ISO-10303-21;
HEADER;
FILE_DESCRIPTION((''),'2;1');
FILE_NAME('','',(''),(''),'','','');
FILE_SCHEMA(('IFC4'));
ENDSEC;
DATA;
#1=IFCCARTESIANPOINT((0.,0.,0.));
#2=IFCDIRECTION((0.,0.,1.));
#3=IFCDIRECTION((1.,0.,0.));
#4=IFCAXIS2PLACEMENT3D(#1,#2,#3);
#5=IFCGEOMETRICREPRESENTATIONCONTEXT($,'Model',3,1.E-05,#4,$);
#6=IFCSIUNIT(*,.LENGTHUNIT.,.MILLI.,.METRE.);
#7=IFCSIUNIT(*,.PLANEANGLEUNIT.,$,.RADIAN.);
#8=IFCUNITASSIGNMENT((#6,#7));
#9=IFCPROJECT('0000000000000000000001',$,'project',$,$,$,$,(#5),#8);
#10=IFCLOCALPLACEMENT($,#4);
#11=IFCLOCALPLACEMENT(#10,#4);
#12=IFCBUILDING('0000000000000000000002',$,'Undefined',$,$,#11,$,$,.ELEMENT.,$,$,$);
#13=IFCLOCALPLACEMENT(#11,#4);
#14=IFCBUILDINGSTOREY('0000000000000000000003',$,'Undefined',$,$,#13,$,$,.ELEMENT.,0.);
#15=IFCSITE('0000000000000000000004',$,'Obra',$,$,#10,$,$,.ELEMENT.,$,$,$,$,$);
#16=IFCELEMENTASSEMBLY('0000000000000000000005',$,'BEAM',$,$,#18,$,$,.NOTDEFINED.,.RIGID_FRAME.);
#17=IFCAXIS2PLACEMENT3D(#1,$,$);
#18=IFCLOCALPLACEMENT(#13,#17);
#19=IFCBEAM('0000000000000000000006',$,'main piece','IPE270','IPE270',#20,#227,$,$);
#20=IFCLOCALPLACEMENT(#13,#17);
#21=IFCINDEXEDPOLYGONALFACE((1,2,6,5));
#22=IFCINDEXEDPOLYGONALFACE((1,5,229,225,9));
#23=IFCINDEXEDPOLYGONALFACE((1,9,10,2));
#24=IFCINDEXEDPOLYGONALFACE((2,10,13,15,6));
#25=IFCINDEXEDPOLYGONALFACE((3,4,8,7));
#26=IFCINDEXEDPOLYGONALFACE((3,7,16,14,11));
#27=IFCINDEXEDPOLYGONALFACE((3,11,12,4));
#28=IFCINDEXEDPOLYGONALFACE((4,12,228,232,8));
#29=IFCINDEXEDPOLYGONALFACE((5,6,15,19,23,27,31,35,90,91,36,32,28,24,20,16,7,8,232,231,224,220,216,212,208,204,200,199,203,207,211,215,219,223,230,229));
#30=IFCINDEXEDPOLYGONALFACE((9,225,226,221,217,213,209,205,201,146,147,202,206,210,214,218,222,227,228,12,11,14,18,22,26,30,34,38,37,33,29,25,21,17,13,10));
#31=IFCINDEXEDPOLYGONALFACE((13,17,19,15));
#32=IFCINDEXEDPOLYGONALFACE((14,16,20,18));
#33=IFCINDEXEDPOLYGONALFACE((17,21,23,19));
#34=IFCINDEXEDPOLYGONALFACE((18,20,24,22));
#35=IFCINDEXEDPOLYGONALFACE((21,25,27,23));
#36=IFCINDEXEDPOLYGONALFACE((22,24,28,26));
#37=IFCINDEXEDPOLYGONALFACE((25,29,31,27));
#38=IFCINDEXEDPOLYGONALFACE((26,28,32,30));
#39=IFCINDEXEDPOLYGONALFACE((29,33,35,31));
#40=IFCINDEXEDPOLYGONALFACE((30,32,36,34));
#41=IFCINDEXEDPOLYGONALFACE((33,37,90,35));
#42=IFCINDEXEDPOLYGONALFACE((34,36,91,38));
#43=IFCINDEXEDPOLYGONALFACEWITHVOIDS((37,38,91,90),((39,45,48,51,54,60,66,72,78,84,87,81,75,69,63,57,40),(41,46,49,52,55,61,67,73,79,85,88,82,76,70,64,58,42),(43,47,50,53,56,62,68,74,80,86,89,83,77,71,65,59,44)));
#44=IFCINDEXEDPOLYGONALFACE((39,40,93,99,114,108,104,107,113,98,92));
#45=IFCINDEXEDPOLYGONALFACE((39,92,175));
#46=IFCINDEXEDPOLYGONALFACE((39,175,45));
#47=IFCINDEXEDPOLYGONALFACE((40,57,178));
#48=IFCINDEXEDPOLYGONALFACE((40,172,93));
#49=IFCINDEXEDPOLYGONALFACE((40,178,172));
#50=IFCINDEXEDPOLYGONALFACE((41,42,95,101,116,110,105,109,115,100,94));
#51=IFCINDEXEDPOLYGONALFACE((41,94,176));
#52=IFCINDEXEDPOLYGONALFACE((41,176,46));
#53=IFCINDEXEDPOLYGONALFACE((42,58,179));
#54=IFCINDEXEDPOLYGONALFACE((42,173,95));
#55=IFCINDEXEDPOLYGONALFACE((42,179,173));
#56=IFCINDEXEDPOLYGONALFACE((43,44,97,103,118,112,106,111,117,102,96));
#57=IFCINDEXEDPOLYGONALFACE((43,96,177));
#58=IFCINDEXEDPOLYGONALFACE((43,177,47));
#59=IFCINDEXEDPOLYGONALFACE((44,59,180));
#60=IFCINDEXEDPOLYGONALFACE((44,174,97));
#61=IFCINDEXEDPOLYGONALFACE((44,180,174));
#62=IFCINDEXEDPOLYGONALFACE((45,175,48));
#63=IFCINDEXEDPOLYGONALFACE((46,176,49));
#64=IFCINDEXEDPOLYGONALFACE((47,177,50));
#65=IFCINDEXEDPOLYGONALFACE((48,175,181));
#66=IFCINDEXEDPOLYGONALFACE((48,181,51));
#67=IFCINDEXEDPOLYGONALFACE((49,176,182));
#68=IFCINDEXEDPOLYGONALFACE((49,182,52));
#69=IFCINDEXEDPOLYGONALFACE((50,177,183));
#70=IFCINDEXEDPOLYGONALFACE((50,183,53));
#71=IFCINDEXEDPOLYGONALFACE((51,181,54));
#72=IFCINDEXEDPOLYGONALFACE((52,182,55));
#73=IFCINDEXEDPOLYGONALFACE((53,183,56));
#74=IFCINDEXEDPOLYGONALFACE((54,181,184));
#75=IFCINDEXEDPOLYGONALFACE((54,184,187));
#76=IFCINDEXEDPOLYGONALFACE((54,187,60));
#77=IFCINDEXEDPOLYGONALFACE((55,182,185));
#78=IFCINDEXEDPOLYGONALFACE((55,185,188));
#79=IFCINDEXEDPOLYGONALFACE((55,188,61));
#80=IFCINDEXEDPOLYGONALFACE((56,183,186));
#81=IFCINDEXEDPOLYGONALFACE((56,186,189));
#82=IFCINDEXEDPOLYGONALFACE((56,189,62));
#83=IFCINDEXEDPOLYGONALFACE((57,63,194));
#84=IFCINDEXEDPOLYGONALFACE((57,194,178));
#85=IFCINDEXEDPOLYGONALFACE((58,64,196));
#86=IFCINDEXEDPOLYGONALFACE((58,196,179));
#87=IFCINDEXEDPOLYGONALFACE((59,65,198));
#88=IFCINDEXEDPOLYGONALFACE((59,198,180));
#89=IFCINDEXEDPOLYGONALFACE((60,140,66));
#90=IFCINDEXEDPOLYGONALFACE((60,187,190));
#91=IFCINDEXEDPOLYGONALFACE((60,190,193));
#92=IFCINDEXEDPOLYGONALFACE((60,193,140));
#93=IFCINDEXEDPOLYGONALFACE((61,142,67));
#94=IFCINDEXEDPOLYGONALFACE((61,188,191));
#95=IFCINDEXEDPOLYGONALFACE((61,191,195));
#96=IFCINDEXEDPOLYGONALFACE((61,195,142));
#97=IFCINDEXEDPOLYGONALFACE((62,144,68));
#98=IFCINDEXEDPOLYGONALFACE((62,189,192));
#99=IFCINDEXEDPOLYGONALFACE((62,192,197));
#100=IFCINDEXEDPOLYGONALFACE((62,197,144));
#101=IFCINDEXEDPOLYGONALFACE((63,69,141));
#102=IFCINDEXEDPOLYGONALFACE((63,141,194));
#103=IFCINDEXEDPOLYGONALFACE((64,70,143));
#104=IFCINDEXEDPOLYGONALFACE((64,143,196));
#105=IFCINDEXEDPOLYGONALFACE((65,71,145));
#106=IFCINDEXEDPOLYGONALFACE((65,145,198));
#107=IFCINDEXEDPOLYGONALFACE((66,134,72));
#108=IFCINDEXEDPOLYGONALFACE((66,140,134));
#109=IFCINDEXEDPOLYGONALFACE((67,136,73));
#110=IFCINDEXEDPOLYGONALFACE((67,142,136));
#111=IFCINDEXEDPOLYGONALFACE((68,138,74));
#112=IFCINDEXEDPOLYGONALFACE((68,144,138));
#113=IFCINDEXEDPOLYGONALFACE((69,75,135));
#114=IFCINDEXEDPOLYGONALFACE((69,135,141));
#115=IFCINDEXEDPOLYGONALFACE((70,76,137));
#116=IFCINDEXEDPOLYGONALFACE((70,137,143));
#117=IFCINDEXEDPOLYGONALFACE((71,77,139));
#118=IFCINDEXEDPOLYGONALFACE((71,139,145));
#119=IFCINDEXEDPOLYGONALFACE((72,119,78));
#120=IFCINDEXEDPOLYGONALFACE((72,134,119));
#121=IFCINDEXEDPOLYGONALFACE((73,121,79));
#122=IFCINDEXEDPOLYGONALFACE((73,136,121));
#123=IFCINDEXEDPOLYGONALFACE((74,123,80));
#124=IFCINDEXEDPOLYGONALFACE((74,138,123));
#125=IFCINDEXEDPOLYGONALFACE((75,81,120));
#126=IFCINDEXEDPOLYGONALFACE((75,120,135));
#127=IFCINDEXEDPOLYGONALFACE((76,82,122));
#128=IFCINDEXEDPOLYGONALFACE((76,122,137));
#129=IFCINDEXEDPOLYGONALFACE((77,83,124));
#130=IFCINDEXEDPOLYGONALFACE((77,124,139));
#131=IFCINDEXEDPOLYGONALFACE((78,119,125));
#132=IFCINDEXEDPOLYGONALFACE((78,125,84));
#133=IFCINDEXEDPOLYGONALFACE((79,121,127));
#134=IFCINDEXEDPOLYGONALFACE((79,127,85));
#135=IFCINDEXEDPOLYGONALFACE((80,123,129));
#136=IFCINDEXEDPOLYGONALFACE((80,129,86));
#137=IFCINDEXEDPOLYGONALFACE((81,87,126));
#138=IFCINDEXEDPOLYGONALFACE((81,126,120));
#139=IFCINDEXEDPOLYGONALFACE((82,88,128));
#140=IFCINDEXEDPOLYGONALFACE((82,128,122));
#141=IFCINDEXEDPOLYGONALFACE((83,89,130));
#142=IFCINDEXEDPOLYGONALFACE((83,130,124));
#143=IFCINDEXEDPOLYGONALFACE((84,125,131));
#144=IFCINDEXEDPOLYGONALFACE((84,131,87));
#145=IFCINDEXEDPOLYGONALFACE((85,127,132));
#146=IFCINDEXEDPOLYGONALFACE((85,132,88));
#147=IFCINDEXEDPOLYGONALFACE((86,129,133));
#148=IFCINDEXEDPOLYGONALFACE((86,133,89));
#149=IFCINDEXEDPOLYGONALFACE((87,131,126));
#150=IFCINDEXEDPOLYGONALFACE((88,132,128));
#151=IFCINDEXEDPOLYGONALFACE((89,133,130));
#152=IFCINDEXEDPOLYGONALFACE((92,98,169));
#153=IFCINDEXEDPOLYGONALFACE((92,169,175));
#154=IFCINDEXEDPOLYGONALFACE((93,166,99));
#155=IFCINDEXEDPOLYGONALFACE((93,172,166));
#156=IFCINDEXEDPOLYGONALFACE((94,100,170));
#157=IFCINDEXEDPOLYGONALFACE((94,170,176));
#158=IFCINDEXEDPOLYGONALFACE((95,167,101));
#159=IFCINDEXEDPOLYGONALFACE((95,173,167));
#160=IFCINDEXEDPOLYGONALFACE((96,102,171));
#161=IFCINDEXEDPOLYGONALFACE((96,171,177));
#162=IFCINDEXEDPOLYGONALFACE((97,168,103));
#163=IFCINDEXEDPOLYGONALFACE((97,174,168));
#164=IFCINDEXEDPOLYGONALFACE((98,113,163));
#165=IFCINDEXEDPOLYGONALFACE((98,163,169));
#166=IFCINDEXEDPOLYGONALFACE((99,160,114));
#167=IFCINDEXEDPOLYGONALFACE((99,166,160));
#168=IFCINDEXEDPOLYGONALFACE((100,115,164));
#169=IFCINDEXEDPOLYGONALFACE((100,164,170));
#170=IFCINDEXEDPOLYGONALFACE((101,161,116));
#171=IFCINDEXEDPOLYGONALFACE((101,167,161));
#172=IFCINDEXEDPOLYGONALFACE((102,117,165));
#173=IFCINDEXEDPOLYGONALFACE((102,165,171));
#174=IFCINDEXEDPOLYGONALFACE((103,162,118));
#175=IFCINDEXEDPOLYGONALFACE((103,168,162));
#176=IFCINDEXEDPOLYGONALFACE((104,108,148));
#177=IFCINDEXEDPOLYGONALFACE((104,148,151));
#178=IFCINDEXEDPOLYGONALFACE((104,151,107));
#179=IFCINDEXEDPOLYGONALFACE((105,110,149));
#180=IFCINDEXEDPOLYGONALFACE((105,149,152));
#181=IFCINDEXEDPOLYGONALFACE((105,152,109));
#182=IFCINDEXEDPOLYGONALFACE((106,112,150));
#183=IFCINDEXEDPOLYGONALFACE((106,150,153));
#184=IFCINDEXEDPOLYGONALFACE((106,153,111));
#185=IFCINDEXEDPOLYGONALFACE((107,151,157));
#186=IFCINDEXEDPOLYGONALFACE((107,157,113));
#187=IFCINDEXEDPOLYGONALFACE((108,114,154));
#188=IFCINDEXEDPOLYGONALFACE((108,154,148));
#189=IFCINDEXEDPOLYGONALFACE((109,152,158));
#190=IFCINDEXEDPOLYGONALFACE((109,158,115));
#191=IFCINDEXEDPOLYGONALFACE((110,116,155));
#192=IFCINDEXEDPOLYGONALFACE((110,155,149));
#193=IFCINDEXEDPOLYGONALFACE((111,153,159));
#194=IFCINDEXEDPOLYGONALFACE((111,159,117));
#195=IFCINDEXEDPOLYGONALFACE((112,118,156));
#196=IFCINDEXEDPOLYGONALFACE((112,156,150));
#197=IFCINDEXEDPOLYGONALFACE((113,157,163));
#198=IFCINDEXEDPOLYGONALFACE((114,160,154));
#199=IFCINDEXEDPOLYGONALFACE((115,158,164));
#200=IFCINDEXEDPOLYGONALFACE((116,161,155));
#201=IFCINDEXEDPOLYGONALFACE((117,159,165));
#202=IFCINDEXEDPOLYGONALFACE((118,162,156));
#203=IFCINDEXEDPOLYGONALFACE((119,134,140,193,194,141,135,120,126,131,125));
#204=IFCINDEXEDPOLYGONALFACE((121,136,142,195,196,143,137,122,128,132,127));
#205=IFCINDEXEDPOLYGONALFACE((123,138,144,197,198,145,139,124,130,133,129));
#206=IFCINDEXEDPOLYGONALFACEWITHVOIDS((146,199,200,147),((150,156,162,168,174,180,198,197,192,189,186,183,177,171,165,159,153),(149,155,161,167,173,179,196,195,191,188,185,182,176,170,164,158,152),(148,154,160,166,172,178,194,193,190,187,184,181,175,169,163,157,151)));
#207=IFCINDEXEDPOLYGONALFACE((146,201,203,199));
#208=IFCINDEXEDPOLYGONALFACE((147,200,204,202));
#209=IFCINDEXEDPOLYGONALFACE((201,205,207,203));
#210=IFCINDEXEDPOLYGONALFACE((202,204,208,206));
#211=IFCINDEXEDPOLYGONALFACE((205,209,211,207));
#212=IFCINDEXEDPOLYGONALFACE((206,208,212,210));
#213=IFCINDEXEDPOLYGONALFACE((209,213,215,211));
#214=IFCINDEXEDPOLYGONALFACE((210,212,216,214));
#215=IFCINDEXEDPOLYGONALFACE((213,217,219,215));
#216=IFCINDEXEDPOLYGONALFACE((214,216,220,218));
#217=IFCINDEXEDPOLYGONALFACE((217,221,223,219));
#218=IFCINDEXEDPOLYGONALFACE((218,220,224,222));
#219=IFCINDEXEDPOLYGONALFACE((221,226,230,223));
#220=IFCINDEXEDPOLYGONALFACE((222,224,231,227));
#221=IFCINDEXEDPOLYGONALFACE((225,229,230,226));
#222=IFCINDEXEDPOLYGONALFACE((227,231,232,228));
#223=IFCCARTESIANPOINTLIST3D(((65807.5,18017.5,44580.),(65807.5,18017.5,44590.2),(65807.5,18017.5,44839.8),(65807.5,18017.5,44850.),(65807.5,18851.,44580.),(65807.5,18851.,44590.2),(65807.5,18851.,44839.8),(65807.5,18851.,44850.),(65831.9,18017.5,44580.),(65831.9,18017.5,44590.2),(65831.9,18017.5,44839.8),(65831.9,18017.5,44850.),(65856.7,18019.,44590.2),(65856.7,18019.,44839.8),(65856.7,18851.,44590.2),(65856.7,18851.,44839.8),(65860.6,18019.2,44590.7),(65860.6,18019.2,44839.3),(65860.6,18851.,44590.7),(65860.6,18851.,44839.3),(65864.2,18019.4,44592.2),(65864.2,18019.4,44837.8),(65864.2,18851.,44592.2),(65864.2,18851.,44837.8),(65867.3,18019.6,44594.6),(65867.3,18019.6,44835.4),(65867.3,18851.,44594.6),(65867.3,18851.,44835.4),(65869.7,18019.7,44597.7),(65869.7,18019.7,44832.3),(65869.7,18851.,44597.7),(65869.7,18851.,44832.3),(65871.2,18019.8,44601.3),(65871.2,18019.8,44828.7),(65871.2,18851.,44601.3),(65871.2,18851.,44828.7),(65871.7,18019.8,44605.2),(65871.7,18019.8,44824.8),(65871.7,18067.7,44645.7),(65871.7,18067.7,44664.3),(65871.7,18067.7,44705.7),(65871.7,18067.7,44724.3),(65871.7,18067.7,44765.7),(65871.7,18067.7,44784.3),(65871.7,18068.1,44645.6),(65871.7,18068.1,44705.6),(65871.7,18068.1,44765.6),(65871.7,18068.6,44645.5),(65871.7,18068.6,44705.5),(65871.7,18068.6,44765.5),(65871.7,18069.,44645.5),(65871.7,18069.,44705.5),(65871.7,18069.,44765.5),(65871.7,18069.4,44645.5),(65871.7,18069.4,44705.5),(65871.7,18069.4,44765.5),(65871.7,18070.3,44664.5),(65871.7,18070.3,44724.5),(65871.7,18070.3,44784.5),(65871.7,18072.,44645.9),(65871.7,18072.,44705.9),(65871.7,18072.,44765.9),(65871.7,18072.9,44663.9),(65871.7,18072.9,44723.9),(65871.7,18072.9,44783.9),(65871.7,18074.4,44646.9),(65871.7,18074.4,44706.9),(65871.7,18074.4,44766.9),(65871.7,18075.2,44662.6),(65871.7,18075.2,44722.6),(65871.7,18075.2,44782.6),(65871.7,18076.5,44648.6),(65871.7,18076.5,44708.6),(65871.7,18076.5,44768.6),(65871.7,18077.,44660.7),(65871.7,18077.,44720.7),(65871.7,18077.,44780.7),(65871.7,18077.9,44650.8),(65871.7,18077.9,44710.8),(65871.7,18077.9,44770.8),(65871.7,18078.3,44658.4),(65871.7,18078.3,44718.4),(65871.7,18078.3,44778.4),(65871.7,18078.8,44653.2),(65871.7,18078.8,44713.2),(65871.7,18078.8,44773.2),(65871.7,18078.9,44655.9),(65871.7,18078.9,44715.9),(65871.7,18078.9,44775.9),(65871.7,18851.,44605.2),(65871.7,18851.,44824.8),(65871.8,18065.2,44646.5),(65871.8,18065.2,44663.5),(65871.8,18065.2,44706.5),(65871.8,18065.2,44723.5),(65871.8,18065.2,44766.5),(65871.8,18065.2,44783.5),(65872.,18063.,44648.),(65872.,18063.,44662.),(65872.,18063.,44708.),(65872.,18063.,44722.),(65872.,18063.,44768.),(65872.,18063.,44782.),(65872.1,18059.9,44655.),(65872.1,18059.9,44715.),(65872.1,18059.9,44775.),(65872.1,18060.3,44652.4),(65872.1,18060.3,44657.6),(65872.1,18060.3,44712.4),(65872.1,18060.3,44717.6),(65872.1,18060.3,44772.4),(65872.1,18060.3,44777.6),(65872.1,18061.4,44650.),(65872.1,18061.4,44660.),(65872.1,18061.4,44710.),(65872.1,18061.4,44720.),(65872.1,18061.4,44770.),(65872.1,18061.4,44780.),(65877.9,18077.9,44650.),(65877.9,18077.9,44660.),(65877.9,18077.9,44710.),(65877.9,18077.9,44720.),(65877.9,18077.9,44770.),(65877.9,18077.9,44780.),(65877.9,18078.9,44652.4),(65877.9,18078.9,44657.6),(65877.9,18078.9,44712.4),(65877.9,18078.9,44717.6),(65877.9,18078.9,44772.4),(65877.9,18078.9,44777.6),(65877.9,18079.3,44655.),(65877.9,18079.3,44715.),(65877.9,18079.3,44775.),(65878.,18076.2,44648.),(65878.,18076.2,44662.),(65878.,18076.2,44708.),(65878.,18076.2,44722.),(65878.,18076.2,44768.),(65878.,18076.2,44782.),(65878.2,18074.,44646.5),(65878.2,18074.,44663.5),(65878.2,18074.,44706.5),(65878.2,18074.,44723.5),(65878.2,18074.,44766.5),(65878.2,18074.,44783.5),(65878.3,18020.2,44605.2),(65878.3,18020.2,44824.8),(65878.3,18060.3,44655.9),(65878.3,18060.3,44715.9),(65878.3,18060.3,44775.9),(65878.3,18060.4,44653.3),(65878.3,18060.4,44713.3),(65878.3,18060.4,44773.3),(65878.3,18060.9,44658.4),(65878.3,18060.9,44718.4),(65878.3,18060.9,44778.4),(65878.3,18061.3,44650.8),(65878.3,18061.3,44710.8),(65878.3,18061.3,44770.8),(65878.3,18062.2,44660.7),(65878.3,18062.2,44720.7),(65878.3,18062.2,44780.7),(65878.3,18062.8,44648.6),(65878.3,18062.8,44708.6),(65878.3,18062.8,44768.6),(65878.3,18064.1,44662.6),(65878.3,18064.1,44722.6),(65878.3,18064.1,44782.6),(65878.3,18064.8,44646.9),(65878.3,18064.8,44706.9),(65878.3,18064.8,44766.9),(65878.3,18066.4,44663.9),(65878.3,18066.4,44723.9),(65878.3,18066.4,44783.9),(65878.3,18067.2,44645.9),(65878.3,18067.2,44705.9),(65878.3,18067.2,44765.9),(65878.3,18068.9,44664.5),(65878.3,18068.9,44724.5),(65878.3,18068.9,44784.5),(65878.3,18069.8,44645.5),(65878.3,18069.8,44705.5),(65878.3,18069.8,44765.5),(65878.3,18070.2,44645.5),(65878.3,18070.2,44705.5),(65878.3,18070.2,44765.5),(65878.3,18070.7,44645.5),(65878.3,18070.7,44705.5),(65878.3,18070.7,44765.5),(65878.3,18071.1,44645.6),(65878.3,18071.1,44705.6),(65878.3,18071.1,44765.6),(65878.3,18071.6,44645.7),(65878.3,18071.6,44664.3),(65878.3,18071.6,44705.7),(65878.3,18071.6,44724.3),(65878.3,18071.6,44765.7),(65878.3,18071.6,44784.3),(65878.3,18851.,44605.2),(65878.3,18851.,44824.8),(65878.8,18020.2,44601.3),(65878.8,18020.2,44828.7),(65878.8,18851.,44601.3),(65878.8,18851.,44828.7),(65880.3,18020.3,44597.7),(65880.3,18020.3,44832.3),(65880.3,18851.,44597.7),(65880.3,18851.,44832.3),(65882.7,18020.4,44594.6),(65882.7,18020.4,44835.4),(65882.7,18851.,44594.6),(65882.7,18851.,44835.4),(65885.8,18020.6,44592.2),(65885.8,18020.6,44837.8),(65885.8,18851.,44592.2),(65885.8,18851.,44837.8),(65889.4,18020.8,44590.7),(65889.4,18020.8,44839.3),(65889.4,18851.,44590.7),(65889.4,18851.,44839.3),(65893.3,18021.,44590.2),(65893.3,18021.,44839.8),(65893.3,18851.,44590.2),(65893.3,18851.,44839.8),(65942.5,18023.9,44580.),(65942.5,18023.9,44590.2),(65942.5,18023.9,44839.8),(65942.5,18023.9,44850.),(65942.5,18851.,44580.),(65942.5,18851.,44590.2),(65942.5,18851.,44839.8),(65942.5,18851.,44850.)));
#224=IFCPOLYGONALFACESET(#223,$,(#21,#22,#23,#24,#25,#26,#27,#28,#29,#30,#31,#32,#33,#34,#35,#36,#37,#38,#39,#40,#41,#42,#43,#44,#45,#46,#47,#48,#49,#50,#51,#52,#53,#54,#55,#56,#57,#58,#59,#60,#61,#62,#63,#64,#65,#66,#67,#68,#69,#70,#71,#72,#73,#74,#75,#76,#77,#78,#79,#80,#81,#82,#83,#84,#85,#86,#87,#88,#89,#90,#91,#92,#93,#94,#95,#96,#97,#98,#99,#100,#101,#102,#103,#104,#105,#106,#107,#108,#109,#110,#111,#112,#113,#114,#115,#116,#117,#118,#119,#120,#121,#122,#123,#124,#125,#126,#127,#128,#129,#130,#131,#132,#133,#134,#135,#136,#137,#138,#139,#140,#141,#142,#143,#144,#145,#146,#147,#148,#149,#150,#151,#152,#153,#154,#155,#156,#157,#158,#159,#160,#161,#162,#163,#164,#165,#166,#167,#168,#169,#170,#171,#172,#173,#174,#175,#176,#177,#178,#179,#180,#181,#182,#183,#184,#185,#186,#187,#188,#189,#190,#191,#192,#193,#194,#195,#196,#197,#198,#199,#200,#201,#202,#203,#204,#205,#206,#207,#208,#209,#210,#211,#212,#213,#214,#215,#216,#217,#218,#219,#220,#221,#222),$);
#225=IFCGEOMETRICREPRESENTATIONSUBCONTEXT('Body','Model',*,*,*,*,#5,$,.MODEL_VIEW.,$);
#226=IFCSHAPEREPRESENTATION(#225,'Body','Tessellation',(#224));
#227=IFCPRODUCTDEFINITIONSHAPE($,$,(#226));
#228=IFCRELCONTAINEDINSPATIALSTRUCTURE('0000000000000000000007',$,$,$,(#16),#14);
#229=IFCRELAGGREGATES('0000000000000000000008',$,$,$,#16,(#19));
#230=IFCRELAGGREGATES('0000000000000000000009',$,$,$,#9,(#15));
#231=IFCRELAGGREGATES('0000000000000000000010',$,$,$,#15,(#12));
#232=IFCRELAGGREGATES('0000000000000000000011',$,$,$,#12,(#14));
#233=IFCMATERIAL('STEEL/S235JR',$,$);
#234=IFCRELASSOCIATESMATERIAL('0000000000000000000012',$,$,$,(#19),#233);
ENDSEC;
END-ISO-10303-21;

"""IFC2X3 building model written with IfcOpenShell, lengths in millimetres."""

from ifc_helpers import new_model, si_unit, frame, origin_with_axes, origin_2d_with_axis, place, context, subcontext, project, spatial, circle, i_section, extrude, clip, halfspace, source, transform, mapped, material, element, aggregate, save


model = new_model("IFC2X3")

# Units and contexts
model_context = context("Model", 3, precision=1e-05, world=origin_with_axes())
body_context = subcontext(model_context, "Body", "Model", "MODEL_VIEW")
ifc_project = project(units=[si_unit("LENGTHUNIT", "METRE", prefix="MILLI"), si_unit("PLANEANGLEUNIT", "RADIAN")], contexts=[model_context])

# Site, building, storey
site_placement = place(None, origin_with_axes())
site = spatial("IfcSite", under=ifc_project, at=site_placement, Name="Obra", CompositionType="ELEMENT")
building_placement = place(site_placement, origin_with_axes())
building = spatial("IfcBuilding", under=site, at=building_placement, Name="Undefined", CompositionType="ELEMENT")
storey_placement = place(building_placement, origin_with_axes())
storey = spatial("IfcBuildingStorey", under=building, at=storey_placement, Name="Undefined", CompositionType="ELEMENT", Elevation=0.0)

# Shared definitions
ifc_material_1 = material(Name="STEEL/S235JR")

# Element assembly, beam, opening
assembly_1_placement = place(storey_placement, origin_with_axes())
assembly_1 = element("IfcElementAssembly", 1, at=assembly_1_placement, inside=storey, Name="BEAM", AssemblyPlace="NOTDEFINED", PredefinedType="RIGID_FRAME")
beam_1_placement = place(assembly_1_placement, frame((65875.0, 18017.5, 44715.0), z_axis=(0.0, 0.0, 1.0), x_axis=(-0.000002, 1.0, 0.0)))
beam_1 = element("IfcBeam", 2, at=beam_1_placement, material=ifc_material_1, Name="main piece", Description="IPE270", ObjectType="IPE270", context=body_context, shape_type="Clipping", body=[
    clip(extrude(i_section(OverallWidth=135.0, OverallDepth=270.0, WebThickness=6.6, FlangeThickness=10.2, FilletRadius=15.0, at=origin_2d_with_axis()), frame((833.4, 0.0, 0.0), z_axis=(-1.0, 0.0, 0.0), x_axis=(0.0, -1.0, 0.0)), (0.0, 0.0, 1.0), 833.4), halfspace(frame((-2.6, 89.1, -120.0), z_axis=(-0.998367, -0.057124, 0.0), x_axis=(0.0, 0.0, 1.0)), False)),
])
shared_shape_1 = source(origin_with_axes(), body_context, "Body", "SweptSolid", [
    extrude(circle(Radius=9.5, at=origin_2d_with_axis()), frame((0.0, -35.4, 0.0), z_axis=(0.0, 1.0, 0.0), x_axis=(1.0, 0.0, 0.0)), (0.0, 0.0, 1.0), 6.8),
])
opening_1_placement = place(assembly_1_placement, frame((65845.9, 18017.9, 44835.0), z_axis=(-0.057107, 0.998368, 0.0), x_axis=(0.0, 0.0, -1.0)))
element("IfcOpeningElement", 3, at=opening_1_placement, cuts=beam_1, ObjectType="Opening", context=body_context, shape_type="MappedRepresentation", body=[
    mapped(shared_shape_1, transform((60.0, 0.0, 50.0))),
    mapped(shared_shape_1, transform((120.0, 0.0, 50.0))),
    mapped(shared_shape_1, transform((180.0, 0.0, 50.0))),
])

aggregate(assembly_1, [beam_1])

save(model, "model.ifc")
